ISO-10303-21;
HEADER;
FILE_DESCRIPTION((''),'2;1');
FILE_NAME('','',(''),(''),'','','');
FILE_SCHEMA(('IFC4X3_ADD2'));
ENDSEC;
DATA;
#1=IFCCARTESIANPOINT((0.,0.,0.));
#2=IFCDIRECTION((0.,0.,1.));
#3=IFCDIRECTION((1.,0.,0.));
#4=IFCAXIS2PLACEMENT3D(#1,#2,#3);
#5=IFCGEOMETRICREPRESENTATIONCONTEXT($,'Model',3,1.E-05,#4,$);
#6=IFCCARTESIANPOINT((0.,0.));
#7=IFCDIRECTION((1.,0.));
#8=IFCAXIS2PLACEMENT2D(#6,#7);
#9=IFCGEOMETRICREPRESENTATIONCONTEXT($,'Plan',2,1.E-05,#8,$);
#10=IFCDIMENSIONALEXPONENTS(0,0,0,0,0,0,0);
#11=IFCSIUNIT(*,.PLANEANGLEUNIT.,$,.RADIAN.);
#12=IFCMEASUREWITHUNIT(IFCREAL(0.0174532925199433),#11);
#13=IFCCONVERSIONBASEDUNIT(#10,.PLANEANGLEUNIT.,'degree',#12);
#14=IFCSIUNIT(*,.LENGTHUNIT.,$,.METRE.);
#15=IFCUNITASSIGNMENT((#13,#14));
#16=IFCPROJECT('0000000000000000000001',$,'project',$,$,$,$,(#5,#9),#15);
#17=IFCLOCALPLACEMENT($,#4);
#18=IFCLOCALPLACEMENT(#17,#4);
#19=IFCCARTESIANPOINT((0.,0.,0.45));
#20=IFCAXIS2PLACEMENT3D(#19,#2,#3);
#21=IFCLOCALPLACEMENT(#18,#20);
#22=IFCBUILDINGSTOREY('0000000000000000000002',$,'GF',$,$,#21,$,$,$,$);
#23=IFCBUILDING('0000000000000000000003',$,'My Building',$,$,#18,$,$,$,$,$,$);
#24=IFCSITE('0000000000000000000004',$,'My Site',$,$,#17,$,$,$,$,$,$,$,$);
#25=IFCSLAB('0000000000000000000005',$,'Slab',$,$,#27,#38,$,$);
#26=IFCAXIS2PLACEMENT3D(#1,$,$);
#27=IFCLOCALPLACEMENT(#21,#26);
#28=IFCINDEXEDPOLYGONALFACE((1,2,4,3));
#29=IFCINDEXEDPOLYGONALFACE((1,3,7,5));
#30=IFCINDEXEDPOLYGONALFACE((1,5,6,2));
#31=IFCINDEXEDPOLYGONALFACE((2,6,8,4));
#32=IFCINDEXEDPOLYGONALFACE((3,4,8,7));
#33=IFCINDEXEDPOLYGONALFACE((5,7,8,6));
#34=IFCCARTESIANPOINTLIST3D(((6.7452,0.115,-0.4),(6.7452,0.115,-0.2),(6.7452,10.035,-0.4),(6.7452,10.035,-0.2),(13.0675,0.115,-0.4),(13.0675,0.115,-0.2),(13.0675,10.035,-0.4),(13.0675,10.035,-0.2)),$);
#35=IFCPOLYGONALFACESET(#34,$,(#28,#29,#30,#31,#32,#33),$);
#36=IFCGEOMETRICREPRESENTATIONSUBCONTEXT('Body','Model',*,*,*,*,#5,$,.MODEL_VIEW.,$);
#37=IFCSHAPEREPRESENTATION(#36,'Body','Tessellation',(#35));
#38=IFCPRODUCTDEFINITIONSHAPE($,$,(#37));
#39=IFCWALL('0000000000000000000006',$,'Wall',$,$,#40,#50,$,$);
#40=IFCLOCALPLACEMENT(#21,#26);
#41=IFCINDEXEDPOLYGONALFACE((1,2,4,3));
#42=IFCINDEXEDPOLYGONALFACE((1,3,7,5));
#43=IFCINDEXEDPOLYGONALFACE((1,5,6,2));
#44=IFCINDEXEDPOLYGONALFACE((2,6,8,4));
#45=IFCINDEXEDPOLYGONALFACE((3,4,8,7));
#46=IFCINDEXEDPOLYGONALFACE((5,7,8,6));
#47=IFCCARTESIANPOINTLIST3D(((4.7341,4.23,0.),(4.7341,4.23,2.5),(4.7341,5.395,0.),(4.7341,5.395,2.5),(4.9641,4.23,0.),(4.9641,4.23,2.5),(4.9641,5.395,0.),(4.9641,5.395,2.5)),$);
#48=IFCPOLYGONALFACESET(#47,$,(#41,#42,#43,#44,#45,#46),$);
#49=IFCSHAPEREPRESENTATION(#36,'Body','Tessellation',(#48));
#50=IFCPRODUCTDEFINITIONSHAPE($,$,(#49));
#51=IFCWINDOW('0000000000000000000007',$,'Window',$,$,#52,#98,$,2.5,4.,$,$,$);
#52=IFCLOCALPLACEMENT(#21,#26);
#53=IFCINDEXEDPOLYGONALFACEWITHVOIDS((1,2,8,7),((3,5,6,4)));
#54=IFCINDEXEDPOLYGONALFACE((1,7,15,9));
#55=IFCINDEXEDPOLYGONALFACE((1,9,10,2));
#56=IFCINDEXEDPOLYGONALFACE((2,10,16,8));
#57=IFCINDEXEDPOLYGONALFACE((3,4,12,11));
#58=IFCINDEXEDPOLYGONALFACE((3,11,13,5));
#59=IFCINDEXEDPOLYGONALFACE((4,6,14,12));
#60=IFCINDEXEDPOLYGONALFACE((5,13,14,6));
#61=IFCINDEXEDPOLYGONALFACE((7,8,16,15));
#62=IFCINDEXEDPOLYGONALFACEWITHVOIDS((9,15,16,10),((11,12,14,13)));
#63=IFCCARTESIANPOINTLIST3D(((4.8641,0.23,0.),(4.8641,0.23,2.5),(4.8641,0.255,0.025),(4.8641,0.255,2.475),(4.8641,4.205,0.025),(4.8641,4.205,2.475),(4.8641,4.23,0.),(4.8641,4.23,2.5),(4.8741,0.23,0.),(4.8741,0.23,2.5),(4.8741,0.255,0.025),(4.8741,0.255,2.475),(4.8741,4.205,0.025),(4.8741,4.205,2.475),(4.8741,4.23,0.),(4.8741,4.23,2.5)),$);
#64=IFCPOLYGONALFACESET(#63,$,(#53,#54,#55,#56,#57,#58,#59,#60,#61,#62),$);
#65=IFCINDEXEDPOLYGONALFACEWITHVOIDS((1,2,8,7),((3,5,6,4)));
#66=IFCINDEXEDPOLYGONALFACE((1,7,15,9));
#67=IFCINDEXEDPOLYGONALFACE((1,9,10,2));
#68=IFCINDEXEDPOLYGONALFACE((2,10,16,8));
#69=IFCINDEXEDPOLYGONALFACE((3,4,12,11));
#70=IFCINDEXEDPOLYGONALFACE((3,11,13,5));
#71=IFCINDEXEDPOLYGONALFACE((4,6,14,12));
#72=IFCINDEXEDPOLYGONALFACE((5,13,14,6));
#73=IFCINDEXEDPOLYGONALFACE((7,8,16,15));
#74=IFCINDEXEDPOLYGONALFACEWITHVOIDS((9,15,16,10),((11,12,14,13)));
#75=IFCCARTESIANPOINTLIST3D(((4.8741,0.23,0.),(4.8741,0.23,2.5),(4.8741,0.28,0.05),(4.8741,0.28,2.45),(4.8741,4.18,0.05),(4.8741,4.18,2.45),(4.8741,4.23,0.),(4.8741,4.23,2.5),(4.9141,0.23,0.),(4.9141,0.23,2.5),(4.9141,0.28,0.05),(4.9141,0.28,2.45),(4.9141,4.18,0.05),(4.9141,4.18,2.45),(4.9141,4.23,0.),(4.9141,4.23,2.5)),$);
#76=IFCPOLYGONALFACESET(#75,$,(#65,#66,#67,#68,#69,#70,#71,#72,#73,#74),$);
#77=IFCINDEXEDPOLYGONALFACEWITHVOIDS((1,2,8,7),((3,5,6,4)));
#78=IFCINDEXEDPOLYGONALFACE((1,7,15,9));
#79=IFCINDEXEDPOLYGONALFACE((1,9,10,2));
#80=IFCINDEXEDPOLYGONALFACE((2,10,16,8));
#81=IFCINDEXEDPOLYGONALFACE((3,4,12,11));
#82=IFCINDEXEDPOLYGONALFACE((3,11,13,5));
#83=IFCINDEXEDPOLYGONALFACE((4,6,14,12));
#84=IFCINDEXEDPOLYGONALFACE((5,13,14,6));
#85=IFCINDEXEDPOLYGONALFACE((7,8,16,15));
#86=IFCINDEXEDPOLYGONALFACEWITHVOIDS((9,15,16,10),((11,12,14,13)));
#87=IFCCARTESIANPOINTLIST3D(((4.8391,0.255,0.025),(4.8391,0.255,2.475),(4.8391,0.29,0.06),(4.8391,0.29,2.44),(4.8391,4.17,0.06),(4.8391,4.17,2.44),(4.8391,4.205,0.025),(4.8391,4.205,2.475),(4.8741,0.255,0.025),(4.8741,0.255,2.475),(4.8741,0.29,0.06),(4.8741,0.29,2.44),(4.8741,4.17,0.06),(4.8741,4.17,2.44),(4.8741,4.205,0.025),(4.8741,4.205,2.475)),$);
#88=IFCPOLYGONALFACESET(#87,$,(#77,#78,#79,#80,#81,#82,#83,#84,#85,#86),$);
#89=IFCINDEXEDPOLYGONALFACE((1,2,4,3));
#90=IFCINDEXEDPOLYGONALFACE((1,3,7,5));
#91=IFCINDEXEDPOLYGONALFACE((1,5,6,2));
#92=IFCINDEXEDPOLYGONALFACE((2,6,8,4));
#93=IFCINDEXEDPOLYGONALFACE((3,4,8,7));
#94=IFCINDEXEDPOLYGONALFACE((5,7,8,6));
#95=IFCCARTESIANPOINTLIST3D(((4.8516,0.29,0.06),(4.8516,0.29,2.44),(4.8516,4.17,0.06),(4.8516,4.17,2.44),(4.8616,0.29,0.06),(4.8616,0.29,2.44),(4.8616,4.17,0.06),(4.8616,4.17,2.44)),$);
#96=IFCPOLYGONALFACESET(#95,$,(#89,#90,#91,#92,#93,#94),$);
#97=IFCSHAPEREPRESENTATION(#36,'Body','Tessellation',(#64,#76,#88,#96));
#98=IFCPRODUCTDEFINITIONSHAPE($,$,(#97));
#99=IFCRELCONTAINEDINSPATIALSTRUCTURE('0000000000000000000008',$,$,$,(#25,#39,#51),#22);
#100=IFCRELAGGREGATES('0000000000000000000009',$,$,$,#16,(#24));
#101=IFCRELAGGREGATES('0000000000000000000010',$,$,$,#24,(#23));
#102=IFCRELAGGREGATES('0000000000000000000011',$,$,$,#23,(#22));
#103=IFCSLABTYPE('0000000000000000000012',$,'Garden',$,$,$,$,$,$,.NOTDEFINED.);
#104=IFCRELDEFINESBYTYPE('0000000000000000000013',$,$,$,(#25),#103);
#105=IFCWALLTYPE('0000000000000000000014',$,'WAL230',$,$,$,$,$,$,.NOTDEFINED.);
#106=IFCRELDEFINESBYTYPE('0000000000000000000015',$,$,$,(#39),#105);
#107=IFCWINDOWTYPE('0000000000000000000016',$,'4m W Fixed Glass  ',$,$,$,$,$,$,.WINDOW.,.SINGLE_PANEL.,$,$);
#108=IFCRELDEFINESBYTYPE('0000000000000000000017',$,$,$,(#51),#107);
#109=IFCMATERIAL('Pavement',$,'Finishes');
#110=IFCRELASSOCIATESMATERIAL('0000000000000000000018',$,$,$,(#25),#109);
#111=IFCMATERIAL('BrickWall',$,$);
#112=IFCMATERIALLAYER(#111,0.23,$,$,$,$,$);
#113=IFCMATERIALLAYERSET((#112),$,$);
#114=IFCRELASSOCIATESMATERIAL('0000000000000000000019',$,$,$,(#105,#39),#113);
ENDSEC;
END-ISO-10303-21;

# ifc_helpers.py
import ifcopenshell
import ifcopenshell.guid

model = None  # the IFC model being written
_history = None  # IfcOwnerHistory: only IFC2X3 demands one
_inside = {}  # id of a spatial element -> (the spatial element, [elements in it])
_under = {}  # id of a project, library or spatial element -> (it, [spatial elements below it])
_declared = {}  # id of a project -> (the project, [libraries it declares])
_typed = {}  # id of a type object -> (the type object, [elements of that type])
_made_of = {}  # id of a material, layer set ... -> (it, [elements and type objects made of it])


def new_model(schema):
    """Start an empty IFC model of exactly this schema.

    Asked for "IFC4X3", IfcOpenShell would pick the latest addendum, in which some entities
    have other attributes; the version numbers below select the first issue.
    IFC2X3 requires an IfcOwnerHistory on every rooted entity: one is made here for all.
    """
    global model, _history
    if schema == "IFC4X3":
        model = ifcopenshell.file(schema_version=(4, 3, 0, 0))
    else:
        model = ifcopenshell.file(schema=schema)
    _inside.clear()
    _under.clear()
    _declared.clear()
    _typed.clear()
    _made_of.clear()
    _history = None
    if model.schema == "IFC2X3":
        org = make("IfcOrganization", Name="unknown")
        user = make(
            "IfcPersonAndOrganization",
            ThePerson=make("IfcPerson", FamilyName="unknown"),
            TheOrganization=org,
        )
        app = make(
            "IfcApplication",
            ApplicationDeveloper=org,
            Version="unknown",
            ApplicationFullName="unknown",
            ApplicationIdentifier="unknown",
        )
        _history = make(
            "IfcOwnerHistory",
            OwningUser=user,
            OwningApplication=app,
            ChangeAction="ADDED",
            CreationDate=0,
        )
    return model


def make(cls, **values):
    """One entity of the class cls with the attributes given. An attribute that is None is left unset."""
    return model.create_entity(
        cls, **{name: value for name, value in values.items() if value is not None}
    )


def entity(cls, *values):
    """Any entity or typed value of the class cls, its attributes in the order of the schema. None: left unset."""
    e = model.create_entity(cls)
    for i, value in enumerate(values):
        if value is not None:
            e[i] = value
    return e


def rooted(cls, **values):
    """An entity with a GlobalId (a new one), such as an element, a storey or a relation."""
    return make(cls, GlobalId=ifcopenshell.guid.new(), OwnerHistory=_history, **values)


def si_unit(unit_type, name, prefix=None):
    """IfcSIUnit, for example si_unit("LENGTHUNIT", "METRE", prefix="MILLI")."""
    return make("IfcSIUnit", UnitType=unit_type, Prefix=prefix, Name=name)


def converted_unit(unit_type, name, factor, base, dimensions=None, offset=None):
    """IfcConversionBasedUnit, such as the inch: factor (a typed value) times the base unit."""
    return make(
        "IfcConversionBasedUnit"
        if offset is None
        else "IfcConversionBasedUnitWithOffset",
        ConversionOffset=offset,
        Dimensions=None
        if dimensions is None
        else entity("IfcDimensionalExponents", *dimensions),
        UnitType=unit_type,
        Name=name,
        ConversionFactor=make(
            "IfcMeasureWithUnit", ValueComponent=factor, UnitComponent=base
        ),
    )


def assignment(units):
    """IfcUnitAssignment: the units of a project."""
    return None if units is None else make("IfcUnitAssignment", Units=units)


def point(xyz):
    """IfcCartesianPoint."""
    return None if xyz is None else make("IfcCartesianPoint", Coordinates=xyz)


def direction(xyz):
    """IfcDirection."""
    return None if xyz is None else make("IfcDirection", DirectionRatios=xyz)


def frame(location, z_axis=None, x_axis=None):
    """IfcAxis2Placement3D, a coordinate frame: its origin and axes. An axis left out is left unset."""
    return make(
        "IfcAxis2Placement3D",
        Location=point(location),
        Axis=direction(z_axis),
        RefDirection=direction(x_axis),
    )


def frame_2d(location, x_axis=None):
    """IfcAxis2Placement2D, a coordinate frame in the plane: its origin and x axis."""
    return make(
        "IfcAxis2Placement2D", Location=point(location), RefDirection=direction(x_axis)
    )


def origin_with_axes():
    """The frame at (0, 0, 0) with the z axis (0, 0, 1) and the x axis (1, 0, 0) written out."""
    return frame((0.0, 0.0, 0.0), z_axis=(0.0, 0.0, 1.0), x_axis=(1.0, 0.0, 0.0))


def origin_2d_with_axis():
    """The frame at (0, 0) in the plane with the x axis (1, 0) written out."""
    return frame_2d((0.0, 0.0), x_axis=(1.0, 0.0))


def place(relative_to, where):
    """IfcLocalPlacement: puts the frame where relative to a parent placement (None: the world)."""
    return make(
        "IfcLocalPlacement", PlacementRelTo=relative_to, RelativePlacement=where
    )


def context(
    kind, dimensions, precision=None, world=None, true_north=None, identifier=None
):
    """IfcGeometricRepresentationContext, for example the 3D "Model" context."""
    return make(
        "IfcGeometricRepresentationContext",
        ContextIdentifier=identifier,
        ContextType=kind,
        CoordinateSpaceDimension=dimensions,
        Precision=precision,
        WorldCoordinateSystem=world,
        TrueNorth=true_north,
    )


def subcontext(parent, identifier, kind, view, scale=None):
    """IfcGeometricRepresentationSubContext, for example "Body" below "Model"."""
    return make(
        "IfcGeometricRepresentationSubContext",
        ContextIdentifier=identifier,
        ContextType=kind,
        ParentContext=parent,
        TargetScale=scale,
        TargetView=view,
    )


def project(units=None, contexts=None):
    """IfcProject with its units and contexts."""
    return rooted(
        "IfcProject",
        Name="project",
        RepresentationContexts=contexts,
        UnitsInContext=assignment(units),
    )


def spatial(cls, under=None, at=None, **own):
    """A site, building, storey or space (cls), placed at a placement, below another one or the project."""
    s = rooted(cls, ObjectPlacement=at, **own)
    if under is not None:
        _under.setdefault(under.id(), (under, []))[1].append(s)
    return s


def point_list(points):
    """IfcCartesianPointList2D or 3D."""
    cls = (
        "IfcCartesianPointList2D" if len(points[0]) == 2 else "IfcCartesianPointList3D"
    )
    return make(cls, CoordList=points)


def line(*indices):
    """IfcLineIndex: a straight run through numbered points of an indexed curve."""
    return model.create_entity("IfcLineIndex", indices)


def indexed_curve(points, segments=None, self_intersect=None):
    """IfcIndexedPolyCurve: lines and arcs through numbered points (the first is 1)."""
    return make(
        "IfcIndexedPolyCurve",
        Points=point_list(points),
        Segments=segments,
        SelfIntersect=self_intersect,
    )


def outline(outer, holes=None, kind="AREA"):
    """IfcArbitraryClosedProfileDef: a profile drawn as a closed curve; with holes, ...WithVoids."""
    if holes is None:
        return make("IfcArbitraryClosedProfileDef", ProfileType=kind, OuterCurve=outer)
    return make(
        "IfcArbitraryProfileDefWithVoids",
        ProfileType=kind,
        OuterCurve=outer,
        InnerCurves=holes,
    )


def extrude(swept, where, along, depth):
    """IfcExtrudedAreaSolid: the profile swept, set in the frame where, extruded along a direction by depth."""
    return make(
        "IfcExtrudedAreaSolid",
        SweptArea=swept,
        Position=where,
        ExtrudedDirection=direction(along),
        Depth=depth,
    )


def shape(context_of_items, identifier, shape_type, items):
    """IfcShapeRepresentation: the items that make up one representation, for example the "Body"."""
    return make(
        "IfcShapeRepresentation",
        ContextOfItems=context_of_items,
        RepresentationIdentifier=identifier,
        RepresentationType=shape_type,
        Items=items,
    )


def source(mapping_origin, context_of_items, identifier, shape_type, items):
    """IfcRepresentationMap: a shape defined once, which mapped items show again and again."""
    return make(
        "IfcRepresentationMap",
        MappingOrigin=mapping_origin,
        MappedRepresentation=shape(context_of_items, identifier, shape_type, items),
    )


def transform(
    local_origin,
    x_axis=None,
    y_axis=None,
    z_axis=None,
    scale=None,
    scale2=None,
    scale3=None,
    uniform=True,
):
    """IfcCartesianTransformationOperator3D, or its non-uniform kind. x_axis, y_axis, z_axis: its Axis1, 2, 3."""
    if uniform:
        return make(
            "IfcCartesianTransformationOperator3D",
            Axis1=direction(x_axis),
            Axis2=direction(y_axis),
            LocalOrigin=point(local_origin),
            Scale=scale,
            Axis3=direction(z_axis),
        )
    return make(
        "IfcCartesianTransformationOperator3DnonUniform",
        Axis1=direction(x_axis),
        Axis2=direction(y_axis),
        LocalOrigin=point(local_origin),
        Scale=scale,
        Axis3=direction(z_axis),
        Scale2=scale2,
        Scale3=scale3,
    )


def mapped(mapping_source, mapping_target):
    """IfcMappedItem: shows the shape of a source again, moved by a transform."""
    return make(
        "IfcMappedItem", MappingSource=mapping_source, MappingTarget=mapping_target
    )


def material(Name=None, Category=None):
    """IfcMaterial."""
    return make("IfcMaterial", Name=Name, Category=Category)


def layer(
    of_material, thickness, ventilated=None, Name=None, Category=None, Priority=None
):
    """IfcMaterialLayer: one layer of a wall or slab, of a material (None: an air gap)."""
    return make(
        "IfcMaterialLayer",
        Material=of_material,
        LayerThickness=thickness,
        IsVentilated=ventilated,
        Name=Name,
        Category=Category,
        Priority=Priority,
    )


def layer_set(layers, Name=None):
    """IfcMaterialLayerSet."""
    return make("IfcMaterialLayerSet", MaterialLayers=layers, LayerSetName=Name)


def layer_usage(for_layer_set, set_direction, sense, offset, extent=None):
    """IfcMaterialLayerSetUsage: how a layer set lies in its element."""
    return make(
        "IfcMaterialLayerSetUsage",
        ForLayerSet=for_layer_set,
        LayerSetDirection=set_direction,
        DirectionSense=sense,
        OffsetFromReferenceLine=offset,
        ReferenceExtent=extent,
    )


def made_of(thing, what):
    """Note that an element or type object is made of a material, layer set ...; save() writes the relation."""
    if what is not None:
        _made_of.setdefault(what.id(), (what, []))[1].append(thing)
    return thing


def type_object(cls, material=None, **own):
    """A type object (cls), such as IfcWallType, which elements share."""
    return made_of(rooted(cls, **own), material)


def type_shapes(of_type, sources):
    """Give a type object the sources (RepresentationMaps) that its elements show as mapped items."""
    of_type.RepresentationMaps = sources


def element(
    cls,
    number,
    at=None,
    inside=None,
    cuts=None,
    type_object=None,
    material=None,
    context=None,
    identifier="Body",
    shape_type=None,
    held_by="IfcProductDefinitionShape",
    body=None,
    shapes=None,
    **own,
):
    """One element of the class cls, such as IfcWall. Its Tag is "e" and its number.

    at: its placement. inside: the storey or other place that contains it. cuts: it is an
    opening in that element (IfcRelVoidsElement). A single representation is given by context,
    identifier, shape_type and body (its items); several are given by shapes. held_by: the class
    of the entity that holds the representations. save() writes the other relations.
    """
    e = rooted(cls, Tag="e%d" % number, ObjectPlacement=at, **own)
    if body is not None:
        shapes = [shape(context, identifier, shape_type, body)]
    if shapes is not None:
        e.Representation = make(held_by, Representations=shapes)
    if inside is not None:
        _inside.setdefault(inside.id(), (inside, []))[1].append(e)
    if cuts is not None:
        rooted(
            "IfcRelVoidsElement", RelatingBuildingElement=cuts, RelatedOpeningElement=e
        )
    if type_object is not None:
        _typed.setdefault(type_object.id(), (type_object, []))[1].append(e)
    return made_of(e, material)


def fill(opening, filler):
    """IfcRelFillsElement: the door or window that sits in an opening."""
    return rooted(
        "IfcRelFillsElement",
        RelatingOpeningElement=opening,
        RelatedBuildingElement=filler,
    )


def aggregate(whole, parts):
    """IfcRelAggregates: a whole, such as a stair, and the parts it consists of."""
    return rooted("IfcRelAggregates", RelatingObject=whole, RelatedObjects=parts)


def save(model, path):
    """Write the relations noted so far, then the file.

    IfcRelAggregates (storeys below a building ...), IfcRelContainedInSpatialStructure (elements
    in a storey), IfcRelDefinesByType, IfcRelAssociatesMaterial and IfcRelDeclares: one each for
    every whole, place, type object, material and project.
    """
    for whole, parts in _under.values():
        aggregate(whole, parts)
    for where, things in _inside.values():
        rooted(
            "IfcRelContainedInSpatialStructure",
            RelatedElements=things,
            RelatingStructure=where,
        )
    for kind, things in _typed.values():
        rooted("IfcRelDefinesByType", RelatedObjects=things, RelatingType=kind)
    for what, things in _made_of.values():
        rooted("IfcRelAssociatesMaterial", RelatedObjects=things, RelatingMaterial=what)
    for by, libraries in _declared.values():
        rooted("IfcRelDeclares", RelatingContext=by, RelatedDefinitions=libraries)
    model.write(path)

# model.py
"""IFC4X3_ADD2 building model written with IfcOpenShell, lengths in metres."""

from ifc_helpers import new_model, entity, si_unit, converted_unit, frame, origin_with_axes, origin_2d_with_axis, place, context, subcontext, project, spatial, line, indexed_curve, outline, extrude, shape, source, transform, mapped, material, layer, layer_set, layer_usage, type_object, type_shapes, element, fill, save


model = new_model("IFC4X3_ADD2")

# Units and contexts
model_context = context("Model", 3, precision=1e-05, world=origin_with_axes())
plan_context = context("Plan", 2, precision=1e-05, world=origin_2d_with_axis())
body_context_1 = subcontext(model_context, "Body", "Model", "MODEL_VIEW")
body_context_2 = subcontext(plan_context, "Body", "Plan", "PLAN_VIEW")
ifc_project = project(units=[converted_unit("PLANEANGLEUNIT", "degree", entity("IfcReal", 0.0174532925199433), si_unit("PLANEANGLEUNIT", "RADIAN"), dimensions=[0, 0, 0, 0, 0, 0, 0]), si_unit("LENGTHUNIT", "METRE")], contexts=[model_context, plan_context])

# Site, building, storey
site_placement = place(None, origin_with_axes())
site = spatial("IfcSite", under=ifc_project, at=site_placement, Name="My Site")
building_placement = place(site_placement, origin_with_axes())
building = spatial("IfcBuilding", under=site, at=building_placement, Name="My Building")
storey_placement = place(building_placement, frame((0.0, 0.0, 0.45), z_axis=(0.0, 0.0, 1.0), x_axis=(1.0, 0.0, 0.0)))
storey = spatial("IfcBuildingStorey", under=building, at=storey_placement, Name="GF")

# Slab
ifc_material_1 = material(Name="Pavement", Category="Finishes")
slab_type = type_object("IfcSlabType", Name="Garden", PredefinedType="NOTDEFINED")
slab_placement = place(storey_placement, frame((6.7452, 0.115, -0.4), z_axis=(0.0, 0.0, 1.0), x_axis=(1.0, 0.0, 0.0)))
element("IfcSlab", 1, at=slab_placement, inside=storey, type_object=slab_type, material=ifc_material_1, Name="Slab", context=body_context_1, shape_type="SweptSolid", body=[
    extrude(outline(indexed_curve([(0.0, 9.92), (0.0, 0.0), (6.3223, 0.0), (6.3223, 9.92)], segments=[line(4, 1), line(1, 2), line(2, 3), line(3, 4)], self_intersect=False)), None, (0.0, 0.0, 1.0), 0.2),
])

# Wall, opening, window
ifc_material_2 = material(Name="BrickWall")
ifc_layer_1 = layer(ifc_material_2, 0.23)
ifc_layer_set_1 = layer_set([ifc_layer_1])
ifc_layer_usage_1 = layer_usage(ifc_layer_set_1, "AXIS2", "POSITIVE", 0.0)
wall_type_1 = type_object("IfcWallType", Name="WAL230", PredefinedType="NOTDEFINED", material=ifc_layer_set_1)
wall_1_placement = place(storey_placement, frame((4.9641, 0.23, 0.0), z_axis=(0.0, 0.0, 1.0), x_axis=(0.0, 1.0, 0.0)))
wall_1 = element("IfcWall", 2, at=wall_1_placement, inside=storey, type_object=wall_type_1, material=ifc_layer_usage_1, Name="Wall", context=body_context_1, shape_type="SweptSolid", body=[
    extrude(outline(indexed_curve([(0.0, 0.0), (0.0, 0.23), (5.165, 0.23), (5.165, 0.0), (0.0, 0.0)], self_intersect=False)), origin_with_axes(), (0.0, 0.0, 1.0), 2.5),
])
shared_shape_1 = source(origin_with_axes(), body_context_1, "Body", "SweptSolid", [
    extrude(outline(indexed_curve([(0.0, 0.0), (4.0, 0.0), (4.0, 2.5), (0.0, 2.5)], segments=[line(1, 2, 3, 4, 1)])), frame((0.0, -0.6, 0.0), z_axis=(0.0, -1.0, 0.0), x_axis=(1.0, 0.0, 0.0)), (0.0, 0.0, -1.0), 1.2),
])
opening_1_placement = place(wall_1_placement, origin_with_axes())
opening_1 = element("IfcOpeningElement", 3, at=opening_1_placement, cuts=wall_1, PredefinedType="OPENING", context=body_context_1, shape_type="MappedRepresentation", body=[
    mapped(shared_shape_1, transform((0.0, 0.0, 0.0), x_axis=(1.0, 0.0, 0.0), y_axis=(0.0, 1.0, 0.0), z_axis=(0.0, 0.0, 1.0), scale=1.0)),
])
window_type_1 = type_object("IfcWindowType", Name="4m W Fixed Glass  ", PartitioningType="SINGLE_PANEL", PredefinedType="WINDOW")
shared_shape_2 = source(origin_with_axes(), body_context_1, "Body", "SweptSolid", [
    extrude(outline(indexed_curve([(0.0, 0.0), (4.0, 0.0), (4.0, 2.5), (0.0, 2.5)], segments=[line(1, 2, 3, 4, 1)]), holes=[indexed_curve([(0.025, 0.025), (3.975, 0.025), (3.975, 2.475), (0.025, 2.475)], segments=[line(1, 2, 3, 4, 1)])]), frame((0.0, 0.09, 0.0), z_axis=(0.0, -1.0, 0.0), x_axis=(1.0, 0.0, 0.0)), (0.0, 0.0, -1.0), 0.01),
    extrude(outline(indexed_curve([(0.0, 0.0), (4.0, 0.0), (4.0, 2.5), (0.0, 2.5)], segments=[line(1, 2, 3, 4, 1)]), holes=[indexed_curve([(0.05, 0.05), (3.95, 0.05), (3.95, 2.45), (0.05, 2.45)], segments=[line(1, 2, 3, 4, 1)])]), frame((0.0, 0.05, 0.0), z_axis=(0.0, -1.0, 0.0), x_axis=(1.0, 0.0, 0.0)), (0.0, 0.0, -1.0), 0.04),
    extrude(outline(indexed_curve([(0.0, 0.0), (3.95, 0.0), (3.95, 2.45), (0.0, 2.45)], segments=[line(1, 2, 3, 4, 1)]), holes=[indexed_curve([(0.035, 0.035), (3.915, 0.035), (3.915, 2.415), (0.035, 2.415)], segments=[line(1, 2, 3, 4, 1)])]), frame((0.025, 0.09, 0.025), z_axis=(0.0, -1.0, 0.0), x_axis=(1.0, 0.0, 0.0)), (0.0, 0.0, -1.0), 0.035),
    extrude(outline(indexed_curve([(0.035, 0.035), (3.915, 0.035), (3.915, 2.415), (0.035, 2.415)], segments=[line(1, 2, 3, 4, 1)])), frame((0.025, 0.1025, 0.025), z_axis=(0.0, -1.0, 0.0), x_axis=(1.0, 0.0, 0.0)), (0.0, 0.0, -1.0), 0.01),
])
shared_shape_3 = source(origin_with_axes(), body_context_2, "Body", "Curve2D", [
    entity("IfcIndexedPolyCurve", entity("IfcCartesianPointList2D", [[0.05, 0.05], [3.95, 0.05]])),
    entity("IfcIndexedPolyCurve", entity("IfcCartesianPointList2D", [[0.0, 0.1], [0.025, 0.1], [0.025, 0.09], [0.05, 0.09], [0.05, 0.05], [0.0, 0.05]]), [entity("IfcLineIndex", [1, 2, 3, 4, 5, 6, 1])]),
    entity("IfcIndexedPolyCurve", entity("IfcCartesianPointList2D", [[4.0, 0.1], [3.975, 0.1], [3.975, 0.09], [3.95, 0.09], [3.95, 0.05], [4.0, 0.05]]), [entity("IfcLineIndex", [1, 2, 3, 4, 5, 6, 1])]),
    entity("IfcIndexedPolyCurve", entity("IfcCartesianPointList2D", [[0.025, 0.09], [0.06, 0.09], [0.06, 0.125], [0.025, 0.125]]), [entity("IfcLineIndex", [1, 2, 3, 4, 1])]),
    entity("IfcIndexedPolyCurve", entity("IfcCartesianPointList2D", [[3.975, 0.09], [3.94, 0.09], [3.94, 0.125], [3.975, 0.125]]), [entity("IfcLineIndex", [1, 2, 3, 4, 1])]),
    entity("IfcIndexedPolyCurve", entity("IfcCartesianPointList2D", [[0.06, 0.09], [3.94, 0.09]])),
    entity("IfcIndexedPolyCurve", entity("IfcCartesianPointList2D", [[0.06, 0.125], [3.94, 0.125]])),
    entity("IfcIndexedPolyCurve", entity("IfcCartesianPointList2D", [[0.06, 0.1075], [3.94, 0.1075]])),
])
type_shapes(window_type_1, [shared_shape_2, shared_shape_3])
window_1_placement = place(opening_1_placement, origin_with_axes())
window_1 = element("IfcWindow", 4, at=window_1_placement, inside=storey, type_object=window_type_1, Name="Window", OverallHeight=2.5, OverallWidth=4.0, shapes=[
    shape(body_context_1, "Body", "MappedRepresentation", [mapped(shared_shape_2, transform((0.0, 0.0, 0.0), x_axis=(1.0, 0.0, 0.0), y_axis=(0.0, 1.0, 0.0), z_axis=(0.0, 0.0, 1.0), scale=1.0))]),
    shape(body_context_2, "Body", "MappedRepresentation", [mapped(shared_shape_3, transform((0.0, 0.0, 0.0), x_axis=(1.0, 0.0, 0.0), y_axis=(0.0, 1.0, 0.0), z_axis=(0.0, 0.0, 1.0), scale=1.0))]),
])
fill(opening_1, window_1)

save(model, "model.ifc")
